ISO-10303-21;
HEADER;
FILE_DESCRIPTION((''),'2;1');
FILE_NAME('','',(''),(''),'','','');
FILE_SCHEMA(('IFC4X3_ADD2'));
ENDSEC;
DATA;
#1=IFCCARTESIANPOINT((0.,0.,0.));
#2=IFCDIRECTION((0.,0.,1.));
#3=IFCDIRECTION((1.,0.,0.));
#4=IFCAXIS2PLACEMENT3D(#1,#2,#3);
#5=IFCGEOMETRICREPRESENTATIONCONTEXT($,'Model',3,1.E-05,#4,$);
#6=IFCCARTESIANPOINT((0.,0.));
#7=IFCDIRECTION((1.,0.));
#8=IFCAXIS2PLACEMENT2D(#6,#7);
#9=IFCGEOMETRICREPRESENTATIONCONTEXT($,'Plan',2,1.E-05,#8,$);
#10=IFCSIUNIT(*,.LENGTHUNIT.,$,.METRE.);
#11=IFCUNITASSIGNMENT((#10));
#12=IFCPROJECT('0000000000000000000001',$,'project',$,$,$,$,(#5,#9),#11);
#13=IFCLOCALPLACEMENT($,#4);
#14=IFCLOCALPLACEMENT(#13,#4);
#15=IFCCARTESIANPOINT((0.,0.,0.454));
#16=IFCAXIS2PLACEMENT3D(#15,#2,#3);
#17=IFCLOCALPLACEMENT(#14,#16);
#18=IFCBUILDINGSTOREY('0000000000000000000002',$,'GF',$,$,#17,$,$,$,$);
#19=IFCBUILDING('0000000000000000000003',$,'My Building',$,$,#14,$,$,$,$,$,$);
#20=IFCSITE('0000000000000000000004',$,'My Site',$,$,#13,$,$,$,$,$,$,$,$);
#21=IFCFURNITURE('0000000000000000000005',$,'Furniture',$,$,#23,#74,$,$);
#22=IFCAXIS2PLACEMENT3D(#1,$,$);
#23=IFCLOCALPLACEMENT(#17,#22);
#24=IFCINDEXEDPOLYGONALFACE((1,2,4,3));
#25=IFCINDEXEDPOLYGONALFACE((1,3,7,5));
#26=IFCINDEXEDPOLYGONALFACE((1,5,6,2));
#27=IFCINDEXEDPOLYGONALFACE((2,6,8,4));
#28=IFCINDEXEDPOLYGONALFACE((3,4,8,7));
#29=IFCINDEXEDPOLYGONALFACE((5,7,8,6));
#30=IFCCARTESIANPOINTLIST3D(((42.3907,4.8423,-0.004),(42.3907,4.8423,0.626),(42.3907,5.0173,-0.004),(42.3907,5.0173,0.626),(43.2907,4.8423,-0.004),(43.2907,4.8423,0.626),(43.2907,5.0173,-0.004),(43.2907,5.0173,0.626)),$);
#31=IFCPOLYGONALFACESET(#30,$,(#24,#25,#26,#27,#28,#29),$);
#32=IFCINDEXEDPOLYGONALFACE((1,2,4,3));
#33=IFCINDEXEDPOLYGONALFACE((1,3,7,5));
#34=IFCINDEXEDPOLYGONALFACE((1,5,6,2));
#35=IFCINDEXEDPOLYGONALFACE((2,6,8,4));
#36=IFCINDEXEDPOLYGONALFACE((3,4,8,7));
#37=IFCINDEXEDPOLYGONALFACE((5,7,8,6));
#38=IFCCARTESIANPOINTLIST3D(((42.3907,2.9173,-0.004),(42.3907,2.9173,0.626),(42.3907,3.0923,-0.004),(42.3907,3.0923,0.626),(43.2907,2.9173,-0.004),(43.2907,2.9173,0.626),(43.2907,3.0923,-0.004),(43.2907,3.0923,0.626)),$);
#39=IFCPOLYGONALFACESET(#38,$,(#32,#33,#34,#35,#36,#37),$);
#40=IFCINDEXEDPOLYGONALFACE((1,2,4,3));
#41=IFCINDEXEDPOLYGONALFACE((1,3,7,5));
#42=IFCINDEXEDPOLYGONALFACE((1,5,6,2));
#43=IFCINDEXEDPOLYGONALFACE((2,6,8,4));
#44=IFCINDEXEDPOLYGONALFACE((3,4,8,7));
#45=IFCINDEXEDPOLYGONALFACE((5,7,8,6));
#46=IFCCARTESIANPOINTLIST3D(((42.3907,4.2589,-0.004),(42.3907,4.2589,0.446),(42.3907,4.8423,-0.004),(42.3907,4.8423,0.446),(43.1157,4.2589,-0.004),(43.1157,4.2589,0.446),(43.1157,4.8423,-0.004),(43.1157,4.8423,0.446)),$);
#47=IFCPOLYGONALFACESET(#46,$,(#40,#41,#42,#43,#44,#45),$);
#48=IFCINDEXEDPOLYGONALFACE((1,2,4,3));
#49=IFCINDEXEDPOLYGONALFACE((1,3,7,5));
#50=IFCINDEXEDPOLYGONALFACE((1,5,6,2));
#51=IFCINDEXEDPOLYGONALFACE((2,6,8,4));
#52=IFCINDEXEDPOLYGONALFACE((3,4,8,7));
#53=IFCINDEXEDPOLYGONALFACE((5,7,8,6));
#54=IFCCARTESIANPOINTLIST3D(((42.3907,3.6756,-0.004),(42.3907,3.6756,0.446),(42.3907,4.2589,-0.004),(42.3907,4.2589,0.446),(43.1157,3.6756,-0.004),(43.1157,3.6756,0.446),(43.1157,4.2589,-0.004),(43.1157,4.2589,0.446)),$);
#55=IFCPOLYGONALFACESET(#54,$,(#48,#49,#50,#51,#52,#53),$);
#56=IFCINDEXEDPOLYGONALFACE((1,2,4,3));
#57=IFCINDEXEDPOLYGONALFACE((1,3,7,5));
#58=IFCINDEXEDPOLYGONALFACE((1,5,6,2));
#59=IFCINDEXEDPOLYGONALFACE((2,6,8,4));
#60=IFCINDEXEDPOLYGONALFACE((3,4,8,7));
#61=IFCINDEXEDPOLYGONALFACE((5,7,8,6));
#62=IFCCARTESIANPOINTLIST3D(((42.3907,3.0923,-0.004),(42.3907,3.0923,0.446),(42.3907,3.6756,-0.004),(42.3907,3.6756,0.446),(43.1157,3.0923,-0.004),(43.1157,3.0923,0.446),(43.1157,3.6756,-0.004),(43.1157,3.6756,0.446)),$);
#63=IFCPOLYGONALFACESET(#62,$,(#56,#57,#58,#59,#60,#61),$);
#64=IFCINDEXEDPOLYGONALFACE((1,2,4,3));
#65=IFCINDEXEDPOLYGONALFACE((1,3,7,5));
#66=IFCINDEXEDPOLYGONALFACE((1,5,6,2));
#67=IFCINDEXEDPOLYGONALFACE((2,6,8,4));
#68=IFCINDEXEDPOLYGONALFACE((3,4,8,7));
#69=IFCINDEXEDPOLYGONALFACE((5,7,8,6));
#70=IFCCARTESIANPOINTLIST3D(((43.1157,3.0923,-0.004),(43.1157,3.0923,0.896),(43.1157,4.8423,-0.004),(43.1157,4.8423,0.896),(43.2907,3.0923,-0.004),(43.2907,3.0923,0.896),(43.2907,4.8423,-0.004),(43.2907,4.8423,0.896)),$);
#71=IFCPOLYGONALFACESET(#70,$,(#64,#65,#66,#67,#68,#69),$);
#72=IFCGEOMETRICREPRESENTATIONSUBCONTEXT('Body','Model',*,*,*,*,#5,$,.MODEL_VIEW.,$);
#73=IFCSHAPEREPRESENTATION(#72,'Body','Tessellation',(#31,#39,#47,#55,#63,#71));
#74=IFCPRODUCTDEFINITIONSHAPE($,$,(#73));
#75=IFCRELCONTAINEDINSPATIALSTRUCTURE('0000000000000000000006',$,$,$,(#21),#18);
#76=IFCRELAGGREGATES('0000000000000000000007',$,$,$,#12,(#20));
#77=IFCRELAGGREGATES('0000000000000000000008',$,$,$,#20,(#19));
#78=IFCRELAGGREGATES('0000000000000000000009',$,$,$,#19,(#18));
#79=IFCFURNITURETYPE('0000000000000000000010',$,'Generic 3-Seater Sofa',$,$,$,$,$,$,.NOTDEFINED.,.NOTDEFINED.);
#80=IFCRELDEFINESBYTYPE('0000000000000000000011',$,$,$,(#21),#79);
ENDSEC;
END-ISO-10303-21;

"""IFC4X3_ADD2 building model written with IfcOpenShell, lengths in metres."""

from ifc_helpers import new_model, entity, si_unit, frame, origin_with_axes, origin_2d_with_axis, place, context, subcontext, project, spatial, line, indexed_curve, outline, extrude, shape, source, transform, mapped, type_object, type_shapes, element, save


model = new_model("IFC4X3_ADD2")

# Units and contexts
model_context = context("Model", 3, precision=1e-05, world=origin_with_axes())
plan_context = context("Plan", 2, precision=1e-05, world=origin_2d_with_axis())
body_context_1 = subcontext(model_context, "Body", "Model", "MODEL_VIEW")
body_context_2 = subcontext(plan_context, "Body", "Plan", "PLAN_VIEW")
ifc_project = project(units=[si_unit("LENGTHUNIT", "METRE")], contexts=[model_context, plan_context])

# Site, building, storey
site_placement = place(None, origin_with_axes())
site = spatial("IfcSite", under=ifc_project, at=site_placement, Name="My Site")
building_placement = place(site_placement, origin_with_axes())
building = spatial("IfcBuilding", under=site, at=building_placement, Name="My Building")
storey_placement = place(building_placement, frame((0.0, 0.0, 0.454), z_axis=(0.0, 0.0, 1.0), x_axis=(1.0, 0.0, 0.0)))
storey = spatial("IfcBuildingStorey", under=building, at=storey_placement, Name="GF")

# Furniture
furniture_type_1 = type_object("IfcFurnitureType", Name="Generic 3-Seater Sofa", AssemblyPlace="NOTDEFINED", PredefinedType="NOTDEFINED")
shared_shape_1 = source(origin_with_axes(), body_context_1, "Body", "SweptSolid", [
    extrude(outline(indexed_curve([(0.0, 0.0), (0.175, 0.0), (0.175, 0.9), (0.0, 0.9)], segments=[line(4, 1), line(1, 2), line(2, 3), line(3, 4)], self_intersect=False)), frame((-1.05, -0.9, 0.0), z_axis=(0.0, 0.0, 1.0), x_axis=(1.0, 0.0, 0.0)), (0.0, 0.0, 1.0), 0.63),
    extrude(outline(indexed_curve([(0.0, 0.0), (0.175, 0.0), (0.175, 0.9), (0.0, 0.9)], segments=[line(1, 2, 3, 4, 1)])), frame((0.875, -0.9, 0.0), z_axis=(0.0, 0.0, 1.0), x_axis=(1.0, 0.0, 0.0)), (0.0, 0.0, 1.0), 0.63),
    extrude(outline(indexed_curve([(0.175, 0.0), (0.7583, 0.0), (0.7583, 0.725), (0.175, 0.725)], segments=[line(1, 2, 3, 4, 1)])), frame((-1.05, -0.9, 0.0), z_axis=(0.0, 0.0, 1.0), x_axis=(1.0, 0.0, 0.0)), (0.0, 0.0, 1.0), 0.45),
    extrude(outline(indexed_curve([(0.7583, 0.0), (1.3417, 0.0), (1.3417, 0.725), (0.7583, 0.725)], segments=[line(1, 2, 3, 4, 1)])), frame((-1.05, -0.9, 0.0), z_axis=(0.0, 0.0, 1.0), x_axis=(1.0, 0.0, 0.0)), (0.0, 0.0, 1.0), 0.45),
    extrude(outline(indexed_curve([(1.3417, 0.0), (1.925, 0.0), (1.925, 0.725), (1.3417, 0.725)], segments=[line(1, 2, 3, 4, 1)])), frame((-1.05, -0.9, 0.0), z_axis=(0.0, 0.0, 1.0), x_axis=(1.0, 0.0, 0.0)), (0.0, 0.0, 1.0), 0.45),
    extrude(outline(indexed_curve([(0.175, 0.725), (1.925, 0.725), (1.925, 0.9), (0.175, 0.9)], segments=[line(1, 2, 3, 4, 1)])), frame((-1.05, -0.9, 0.0), z_axis=(0.0, 0.0, 1.0), x_axis=(1.0, 0.0, 0.0)), (0.0, 0.0, 1.0), 0.9),
])
shared_shape_2 = source(origin_with_axes(), body_context_2, "Body", "Annotation2D", [
    entity("IfcGeometricCurveSet", [entity("IfcIndexedPolyCurve", entity("IfcCartesianPointList2D", [[0.2917, -0.175], [0.2917, -0.9], [0.875, -0.9], [0.875, -0.175], [-0.875, -0.175], [-0.875, 0.0], [0.875, 0.0], [1.05, 0.0], [1.05, -0.9], [0.875, -0.9], [0.875, 0.0], [0.875, -0.175], [0.2917, -0.175], [-0.2917, -0.175], [-0.2917, -0.9], [-0.875, -0.9], [-0.875, 0.0], [-1.05, 0.0], [-1.05, -0.9], [-0.875, -0.9], [-0.875, -0.175], [-0.2917, -0.175]])), entity("IfcIndexedPolyCurve", entity("IfcCartesianPointList2D", [[0.2917, -0.9], [-0.2917, -0.9]]))]),
])
type_shapes(furniture_type_1, [shared_shape_1, shared_shape_2])
furniture_1_placement = place(storey_placement, frame((43.2907, 3.9673, -0.004), z_axis=(0.0, 0.0, 1.0), x_axis=(0.0, -1.0, 0.0)))
element("IfcFurniture", 1, at=furniture_1_placement, inside=storey, type_object=furniture_type_1, Name="Furniture", shapes=[
    shape(body_context_1, "Body", "MappedRepresentation", [mapped(shared_shape_1, transform((0.0, 0.0, 0.0), x_axis=(1.0, 0.0, 0.0), y_axis=(0.0, 1.0, 0.0), z_axis=(0.0, 0.0, 1.0), scale=1.0))]),
    shape(body_context_2, "Body", "MappedRepresentation", [mapped(shared_shape_2, transform((0.0, 0.0, 0.0), x_axis=(1.0, 0.0, 0.0), y_axis=(0.0, 1.0, 0.0), z_axis=(0.0, 0.0, 1.0), scale=1.0))]),
])

save(model, "model.ifc")
